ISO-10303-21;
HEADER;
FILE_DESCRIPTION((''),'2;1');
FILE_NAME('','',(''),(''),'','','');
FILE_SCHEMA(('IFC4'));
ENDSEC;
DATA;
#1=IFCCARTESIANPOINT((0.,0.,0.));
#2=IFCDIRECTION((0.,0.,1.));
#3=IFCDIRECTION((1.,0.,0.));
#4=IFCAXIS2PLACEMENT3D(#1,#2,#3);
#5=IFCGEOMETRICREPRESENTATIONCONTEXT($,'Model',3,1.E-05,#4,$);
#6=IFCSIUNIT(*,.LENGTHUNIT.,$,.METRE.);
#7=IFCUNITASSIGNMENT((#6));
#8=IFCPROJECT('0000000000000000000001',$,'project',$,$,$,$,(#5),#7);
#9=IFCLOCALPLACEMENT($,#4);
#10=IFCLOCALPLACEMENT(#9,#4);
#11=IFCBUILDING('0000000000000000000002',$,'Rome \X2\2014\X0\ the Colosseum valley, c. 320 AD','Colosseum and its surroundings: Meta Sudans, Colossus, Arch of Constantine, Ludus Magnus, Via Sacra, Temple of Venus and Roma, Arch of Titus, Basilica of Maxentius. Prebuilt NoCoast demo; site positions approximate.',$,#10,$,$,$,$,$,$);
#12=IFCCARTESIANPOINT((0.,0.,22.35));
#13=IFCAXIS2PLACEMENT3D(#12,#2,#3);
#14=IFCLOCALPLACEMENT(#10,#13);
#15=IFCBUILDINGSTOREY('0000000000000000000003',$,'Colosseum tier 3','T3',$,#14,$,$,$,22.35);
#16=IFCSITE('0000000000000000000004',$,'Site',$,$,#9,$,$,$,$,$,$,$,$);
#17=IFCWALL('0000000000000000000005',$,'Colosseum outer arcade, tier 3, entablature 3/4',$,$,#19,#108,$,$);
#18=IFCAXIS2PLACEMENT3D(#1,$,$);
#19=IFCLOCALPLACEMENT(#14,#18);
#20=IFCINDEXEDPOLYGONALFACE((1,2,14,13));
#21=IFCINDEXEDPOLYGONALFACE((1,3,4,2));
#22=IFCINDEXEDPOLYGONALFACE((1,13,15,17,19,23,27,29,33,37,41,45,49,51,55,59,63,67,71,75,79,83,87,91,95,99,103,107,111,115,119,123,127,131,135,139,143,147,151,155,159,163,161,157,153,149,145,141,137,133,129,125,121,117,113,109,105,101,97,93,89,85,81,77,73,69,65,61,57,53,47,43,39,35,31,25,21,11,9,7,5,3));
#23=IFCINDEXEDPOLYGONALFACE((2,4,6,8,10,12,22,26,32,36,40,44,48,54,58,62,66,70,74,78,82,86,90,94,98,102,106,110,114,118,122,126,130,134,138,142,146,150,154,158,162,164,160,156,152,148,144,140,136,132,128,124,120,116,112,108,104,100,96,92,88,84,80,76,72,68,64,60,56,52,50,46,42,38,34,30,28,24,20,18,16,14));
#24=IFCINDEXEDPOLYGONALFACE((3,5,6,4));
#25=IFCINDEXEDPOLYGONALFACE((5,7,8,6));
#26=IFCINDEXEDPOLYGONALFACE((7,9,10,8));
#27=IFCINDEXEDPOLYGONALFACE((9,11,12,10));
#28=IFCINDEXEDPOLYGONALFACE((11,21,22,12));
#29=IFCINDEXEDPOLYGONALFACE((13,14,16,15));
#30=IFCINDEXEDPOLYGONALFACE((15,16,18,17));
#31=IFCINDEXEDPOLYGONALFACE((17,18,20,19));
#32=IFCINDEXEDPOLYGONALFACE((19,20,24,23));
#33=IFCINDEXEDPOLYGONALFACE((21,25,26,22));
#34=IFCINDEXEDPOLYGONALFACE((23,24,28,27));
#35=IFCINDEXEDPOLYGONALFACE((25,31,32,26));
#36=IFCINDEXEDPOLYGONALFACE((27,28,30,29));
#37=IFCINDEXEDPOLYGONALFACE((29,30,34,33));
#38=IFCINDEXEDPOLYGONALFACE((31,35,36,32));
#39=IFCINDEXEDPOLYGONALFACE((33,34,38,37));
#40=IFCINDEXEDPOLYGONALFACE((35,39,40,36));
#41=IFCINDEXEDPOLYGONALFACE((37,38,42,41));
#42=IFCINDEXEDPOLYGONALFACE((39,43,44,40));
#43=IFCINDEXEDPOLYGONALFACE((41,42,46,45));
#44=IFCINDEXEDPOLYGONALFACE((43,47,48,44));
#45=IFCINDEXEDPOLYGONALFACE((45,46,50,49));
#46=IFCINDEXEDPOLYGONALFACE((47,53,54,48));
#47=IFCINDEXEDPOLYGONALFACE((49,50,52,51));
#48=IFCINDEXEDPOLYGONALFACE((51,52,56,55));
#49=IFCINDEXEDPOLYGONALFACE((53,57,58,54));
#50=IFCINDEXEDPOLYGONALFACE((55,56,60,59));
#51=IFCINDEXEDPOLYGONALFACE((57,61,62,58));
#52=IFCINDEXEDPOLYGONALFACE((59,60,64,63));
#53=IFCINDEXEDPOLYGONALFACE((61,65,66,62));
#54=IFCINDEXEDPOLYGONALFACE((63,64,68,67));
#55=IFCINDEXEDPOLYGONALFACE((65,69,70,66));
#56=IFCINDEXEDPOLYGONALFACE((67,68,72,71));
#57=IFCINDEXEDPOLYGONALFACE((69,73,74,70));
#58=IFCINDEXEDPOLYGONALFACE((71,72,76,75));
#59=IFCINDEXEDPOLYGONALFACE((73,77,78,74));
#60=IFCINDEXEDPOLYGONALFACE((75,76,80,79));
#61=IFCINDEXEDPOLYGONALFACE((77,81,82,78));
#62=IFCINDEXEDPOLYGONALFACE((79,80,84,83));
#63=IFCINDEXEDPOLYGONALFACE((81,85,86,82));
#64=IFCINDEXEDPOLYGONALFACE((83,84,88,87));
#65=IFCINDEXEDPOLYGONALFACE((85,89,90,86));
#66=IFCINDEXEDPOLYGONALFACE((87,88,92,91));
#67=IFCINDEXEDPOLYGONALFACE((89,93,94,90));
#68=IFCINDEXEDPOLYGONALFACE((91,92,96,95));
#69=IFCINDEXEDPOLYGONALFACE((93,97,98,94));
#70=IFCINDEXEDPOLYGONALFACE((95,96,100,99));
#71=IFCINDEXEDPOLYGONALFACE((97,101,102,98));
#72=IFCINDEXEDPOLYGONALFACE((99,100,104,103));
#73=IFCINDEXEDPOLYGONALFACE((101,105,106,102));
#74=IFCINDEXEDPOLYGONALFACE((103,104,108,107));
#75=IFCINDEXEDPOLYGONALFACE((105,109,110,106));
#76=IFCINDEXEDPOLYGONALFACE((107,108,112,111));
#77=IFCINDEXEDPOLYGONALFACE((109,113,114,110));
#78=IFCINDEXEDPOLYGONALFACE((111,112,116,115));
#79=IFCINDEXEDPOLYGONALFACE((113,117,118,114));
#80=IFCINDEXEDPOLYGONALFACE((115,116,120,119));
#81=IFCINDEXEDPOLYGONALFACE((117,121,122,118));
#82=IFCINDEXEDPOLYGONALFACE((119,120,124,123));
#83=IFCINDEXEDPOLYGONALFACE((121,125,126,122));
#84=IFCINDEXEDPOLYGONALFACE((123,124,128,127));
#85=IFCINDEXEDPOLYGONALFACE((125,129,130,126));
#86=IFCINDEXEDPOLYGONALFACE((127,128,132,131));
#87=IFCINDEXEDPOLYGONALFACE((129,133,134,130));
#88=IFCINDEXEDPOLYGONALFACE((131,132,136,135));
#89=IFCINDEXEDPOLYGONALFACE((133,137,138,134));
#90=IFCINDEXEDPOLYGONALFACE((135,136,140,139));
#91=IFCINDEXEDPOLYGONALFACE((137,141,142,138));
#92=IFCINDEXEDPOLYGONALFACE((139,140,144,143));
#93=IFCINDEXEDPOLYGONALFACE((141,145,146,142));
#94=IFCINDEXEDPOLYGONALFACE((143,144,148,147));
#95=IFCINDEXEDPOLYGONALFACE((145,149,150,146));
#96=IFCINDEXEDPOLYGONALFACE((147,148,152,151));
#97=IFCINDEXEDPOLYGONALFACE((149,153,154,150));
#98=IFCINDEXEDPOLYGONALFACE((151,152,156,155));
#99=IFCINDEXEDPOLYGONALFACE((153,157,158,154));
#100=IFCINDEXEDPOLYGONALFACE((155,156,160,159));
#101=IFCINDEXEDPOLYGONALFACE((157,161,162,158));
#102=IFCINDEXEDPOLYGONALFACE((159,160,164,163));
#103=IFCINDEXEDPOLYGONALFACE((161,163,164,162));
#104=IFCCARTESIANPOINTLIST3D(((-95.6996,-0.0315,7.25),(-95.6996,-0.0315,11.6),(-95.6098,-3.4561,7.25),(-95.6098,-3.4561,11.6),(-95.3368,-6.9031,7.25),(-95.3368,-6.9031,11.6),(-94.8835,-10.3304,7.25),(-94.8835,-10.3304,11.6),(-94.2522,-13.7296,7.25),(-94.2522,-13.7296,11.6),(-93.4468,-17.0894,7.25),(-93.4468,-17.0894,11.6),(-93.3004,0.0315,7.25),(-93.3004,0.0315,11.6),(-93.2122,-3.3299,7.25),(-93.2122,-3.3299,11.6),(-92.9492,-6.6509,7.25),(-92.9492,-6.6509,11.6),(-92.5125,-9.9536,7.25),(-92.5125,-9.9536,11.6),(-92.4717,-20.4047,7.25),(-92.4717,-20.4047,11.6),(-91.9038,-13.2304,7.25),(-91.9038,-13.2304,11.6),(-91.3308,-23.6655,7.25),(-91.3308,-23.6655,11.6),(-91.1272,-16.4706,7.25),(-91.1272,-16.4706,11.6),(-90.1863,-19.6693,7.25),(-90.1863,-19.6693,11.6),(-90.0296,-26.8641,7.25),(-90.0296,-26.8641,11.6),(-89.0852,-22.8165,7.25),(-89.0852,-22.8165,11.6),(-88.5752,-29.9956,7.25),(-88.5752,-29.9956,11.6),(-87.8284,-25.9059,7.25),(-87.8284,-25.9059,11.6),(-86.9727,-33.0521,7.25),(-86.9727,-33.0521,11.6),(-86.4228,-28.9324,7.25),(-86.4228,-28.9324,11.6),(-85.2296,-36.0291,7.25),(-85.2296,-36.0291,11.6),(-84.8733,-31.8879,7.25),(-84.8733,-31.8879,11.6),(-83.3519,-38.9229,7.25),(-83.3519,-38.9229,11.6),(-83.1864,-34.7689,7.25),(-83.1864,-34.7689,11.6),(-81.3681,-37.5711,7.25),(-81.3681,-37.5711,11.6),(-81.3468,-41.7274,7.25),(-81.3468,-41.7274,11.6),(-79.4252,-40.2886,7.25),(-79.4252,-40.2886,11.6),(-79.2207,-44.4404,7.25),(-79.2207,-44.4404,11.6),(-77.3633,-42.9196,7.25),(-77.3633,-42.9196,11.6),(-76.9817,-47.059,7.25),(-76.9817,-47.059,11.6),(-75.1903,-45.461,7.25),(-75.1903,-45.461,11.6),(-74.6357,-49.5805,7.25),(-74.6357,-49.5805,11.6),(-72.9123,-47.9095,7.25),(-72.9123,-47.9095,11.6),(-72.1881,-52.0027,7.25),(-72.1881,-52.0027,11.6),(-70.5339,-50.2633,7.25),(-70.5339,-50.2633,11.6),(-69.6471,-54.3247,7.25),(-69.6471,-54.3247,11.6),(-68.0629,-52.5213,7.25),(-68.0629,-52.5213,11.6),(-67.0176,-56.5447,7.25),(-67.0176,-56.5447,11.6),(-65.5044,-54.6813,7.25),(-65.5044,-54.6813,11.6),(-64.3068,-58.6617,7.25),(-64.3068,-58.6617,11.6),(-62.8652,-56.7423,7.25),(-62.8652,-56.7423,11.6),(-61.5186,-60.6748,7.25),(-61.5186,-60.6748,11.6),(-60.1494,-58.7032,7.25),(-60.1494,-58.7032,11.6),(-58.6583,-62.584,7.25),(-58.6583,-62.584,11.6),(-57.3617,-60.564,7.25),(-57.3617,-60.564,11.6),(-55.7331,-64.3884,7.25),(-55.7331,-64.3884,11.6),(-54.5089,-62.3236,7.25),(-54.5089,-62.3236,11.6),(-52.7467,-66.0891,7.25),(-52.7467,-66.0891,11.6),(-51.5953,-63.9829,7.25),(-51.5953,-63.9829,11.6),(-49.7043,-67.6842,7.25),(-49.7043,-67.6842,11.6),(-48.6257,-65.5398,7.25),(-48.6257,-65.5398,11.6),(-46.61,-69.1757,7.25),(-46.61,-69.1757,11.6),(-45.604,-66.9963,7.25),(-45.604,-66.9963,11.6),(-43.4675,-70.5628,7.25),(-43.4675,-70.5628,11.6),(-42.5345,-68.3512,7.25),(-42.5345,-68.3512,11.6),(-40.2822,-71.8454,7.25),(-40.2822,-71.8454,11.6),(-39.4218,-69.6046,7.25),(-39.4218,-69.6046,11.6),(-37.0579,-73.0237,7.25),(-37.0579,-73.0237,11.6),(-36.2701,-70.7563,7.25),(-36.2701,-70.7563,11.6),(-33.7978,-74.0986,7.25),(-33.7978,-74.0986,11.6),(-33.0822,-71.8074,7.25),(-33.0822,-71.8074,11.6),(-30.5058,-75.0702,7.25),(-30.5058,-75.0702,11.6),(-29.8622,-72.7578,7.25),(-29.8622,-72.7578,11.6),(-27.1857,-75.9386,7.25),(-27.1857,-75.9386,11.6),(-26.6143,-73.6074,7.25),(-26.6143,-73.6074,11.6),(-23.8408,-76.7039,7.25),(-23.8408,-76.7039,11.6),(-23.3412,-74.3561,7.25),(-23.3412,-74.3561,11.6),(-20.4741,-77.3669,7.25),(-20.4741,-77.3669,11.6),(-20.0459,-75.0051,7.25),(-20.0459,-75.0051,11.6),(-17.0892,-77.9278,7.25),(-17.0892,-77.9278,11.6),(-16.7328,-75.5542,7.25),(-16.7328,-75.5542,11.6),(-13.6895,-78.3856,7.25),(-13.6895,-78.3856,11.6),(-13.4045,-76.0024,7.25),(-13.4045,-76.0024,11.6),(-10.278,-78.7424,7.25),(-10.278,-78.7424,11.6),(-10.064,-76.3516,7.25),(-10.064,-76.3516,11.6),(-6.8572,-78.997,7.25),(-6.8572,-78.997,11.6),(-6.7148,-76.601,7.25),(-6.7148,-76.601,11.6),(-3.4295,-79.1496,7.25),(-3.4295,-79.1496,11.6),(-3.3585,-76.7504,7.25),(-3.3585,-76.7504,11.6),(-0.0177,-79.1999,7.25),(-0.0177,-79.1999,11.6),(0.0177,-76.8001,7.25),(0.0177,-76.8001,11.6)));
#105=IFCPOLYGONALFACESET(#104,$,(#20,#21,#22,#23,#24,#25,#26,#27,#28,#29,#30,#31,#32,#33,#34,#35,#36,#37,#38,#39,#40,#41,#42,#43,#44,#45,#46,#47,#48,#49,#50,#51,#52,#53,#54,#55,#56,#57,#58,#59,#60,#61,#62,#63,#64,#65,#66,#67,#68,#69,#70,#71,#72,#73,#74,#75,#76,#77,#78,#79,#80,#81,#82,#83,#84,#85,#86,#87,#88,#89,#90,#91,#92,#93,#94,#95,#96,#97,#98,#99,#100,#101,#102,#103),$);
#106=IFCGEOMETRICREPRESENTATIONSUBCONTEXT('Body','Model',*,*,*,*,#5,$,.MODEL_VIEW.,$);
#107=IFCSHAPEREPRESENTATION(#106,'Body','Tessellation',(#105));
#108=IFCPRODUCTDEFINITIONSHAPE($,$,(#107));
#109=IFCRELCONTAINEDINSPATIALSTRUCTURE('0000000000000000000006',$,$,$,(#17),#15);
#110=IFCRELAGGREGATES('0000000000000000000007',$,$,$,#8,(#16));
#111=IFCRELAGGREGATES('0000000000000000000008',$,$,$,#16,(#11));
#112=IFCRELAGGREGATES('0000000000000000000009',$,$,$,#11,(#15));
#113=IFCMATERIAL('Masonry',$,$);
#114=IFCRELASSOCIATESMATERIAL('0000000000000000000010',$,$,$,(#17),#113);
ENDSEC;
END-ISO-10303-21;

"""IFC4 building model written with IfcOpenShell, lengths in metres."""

from ifc_helpers import new_model, si_unit, frame, origin_with_axes, place, context, subcontext, project, spatial, polyline, outline, extrude, material, element, save


model = new_model("IFC4")

# Units and contexts
model_context = context("Model", 3, precision=1e-05, world=origin_with_axes())
body_context = subcontext(model_context, "Body", "Model", "MODEL_VIEW")
ifc_project = project(units=[si_unit("LENGTHUNIT", "METRE")], contexts=[model_context])

# Site, building, storey
site_placement = place(None, origin_with_axes())
site = spatial("IfcSite", under=ifc_project, at=site_placement, Name="Site")
building_placement = place(site_placement, origin_with_axes())
building = spatial("IfcBuilding", under=site, at=building_placement, Name="Rome — the Colosseum valley, c. 320 AD", Description="Colosseum and its surroundings: Meta Sudans, Colossus, Arch of Constantine, Ludus Magnus, Via Sacra, Temple of Venus and Roma, Arch of Titus, Basilica of Maxentius. Prebuilt NoCoast demo; site positions approximate.")
storey_placement = place(building_placement, frame((0.0, 0.0, 22.35), z_axis=(0.0, 0.0, 1.0), x_axis=(1.0, 0.0, 0.0)))
storey = spatial("IfcBuildingStorey", under=building, at=storey_placement, Name="Colosseum tier 3", Description="T3", Elevation=22.35)

# Wall
ifc_material_1 = material(Name="Masonry")
wall_1_placement = place(storey_placement, frame((0.0, 0.0, 7.25), z_axis=(0.0, 0.0, 1.0), x_axis=(1.0, 0.0, 0.0)))
element("IfcWall", 1, at=wall_1_placement, inside=storey, material=ifc_material_1, Name="Colosseum outer arcade, tier 3, entablature 3/4", context=body_context, shape_type="SweptSolid", body=[
    extrude(outline(polyline([(-93.2122, -3.3299), (-92.9492, -6.6509), (-92.5125, -9.9536), (-91.9038, -13.2304), (-91.1272, -16.4706), (-90.1863, -19.6693), (-89.0852, -22.8165), (-87.8284, -25.9059), (-86.4228, -28.9324), (-84.8733, -31.8879), (-83.1864, -34.7689), (-81.3681, -37.5711), (-79.4252, -40.2886), (-77.3633, -42.9196), (-75.1903, -45.461), (-72.9123, -47.9095), (-70.5339, -50.2633), (-68.0629, -52.5213), (-65.5044, -54.6813), (-62.8652, -56.7423), (-60.1494, -58.7032), (-57.3617, -60.564), (-54.5089, -62.3236), (-51.5953, -63.9829), (-48.6257, -65.5398), (-45.604, -66.9963), (-42.5345, -68.3512), (-39.4218, -69.6046), (-36.2701, -70.7563), (-33.0822, -71.8074), (-29.8622, -72.7578), (-26.6143, -73.6074), (-23.3412, -74.3561), (-20.0459, -75.0051), (-16.7328, -75.5542), (-13.4045, -76.0024), (-10.064, -76.3516), (-6.7148, -76.601), (-3.3585, -76.7504), (0.0177, -76.8001), (-0.0177, -79.1999), (-3.4295, -79.1496), (-6.8572, -78.997), (-10.278, -78.7424), (-13.6895, -78.3856), (-17.0892, -77.9278), (-20.4741, -77.3669), (-23.8408, -76.7039), (-27.1857, -75.9386), (-30.5058, -75.0702), (-33.7978, -74.0986), (-37.0579, -73.0237), (-40.2822, -71.8454), (-43.4675, -70.5628), (-46.61, -69.1757), (-49.7043, -67.6842), (-52.7467, -66.0891), (-55.7331, -64.3884), (-58.6583, -62.584), (-61.5186, -60.6748), (-64.3068, -58.6617), (-67.0176, -56.5447), (-69.6471, -54.3247), (-72.1881, -52.0027), (-74.6357, -49.5805), (-76.9817, -47.059), (-79.2207, -44.4404), (-81.3468, -41.7274), (-83.3519, -38.9229), (-85.2296, -36.0291), (-86.9727, -33.0521), (-88.5752, -29.9956), (-90.0296, -26.8641), (-91.3308, -23.6655), (-92.4717, -20.4047), (-93.4468, -17.0894), (-94.2522, -13.7296), (-94.8835, -10.3304), (-95.3368, -6.9031), (-95.6098, -3.4561), (-95.6996, -0.0315), (-93.3004, 0.0315), (-93.2122, -3.3299)])), origin_with_axes(), (0.0, 0.0, 1.0), 4.35),
])

save(model, "model.ifc")
